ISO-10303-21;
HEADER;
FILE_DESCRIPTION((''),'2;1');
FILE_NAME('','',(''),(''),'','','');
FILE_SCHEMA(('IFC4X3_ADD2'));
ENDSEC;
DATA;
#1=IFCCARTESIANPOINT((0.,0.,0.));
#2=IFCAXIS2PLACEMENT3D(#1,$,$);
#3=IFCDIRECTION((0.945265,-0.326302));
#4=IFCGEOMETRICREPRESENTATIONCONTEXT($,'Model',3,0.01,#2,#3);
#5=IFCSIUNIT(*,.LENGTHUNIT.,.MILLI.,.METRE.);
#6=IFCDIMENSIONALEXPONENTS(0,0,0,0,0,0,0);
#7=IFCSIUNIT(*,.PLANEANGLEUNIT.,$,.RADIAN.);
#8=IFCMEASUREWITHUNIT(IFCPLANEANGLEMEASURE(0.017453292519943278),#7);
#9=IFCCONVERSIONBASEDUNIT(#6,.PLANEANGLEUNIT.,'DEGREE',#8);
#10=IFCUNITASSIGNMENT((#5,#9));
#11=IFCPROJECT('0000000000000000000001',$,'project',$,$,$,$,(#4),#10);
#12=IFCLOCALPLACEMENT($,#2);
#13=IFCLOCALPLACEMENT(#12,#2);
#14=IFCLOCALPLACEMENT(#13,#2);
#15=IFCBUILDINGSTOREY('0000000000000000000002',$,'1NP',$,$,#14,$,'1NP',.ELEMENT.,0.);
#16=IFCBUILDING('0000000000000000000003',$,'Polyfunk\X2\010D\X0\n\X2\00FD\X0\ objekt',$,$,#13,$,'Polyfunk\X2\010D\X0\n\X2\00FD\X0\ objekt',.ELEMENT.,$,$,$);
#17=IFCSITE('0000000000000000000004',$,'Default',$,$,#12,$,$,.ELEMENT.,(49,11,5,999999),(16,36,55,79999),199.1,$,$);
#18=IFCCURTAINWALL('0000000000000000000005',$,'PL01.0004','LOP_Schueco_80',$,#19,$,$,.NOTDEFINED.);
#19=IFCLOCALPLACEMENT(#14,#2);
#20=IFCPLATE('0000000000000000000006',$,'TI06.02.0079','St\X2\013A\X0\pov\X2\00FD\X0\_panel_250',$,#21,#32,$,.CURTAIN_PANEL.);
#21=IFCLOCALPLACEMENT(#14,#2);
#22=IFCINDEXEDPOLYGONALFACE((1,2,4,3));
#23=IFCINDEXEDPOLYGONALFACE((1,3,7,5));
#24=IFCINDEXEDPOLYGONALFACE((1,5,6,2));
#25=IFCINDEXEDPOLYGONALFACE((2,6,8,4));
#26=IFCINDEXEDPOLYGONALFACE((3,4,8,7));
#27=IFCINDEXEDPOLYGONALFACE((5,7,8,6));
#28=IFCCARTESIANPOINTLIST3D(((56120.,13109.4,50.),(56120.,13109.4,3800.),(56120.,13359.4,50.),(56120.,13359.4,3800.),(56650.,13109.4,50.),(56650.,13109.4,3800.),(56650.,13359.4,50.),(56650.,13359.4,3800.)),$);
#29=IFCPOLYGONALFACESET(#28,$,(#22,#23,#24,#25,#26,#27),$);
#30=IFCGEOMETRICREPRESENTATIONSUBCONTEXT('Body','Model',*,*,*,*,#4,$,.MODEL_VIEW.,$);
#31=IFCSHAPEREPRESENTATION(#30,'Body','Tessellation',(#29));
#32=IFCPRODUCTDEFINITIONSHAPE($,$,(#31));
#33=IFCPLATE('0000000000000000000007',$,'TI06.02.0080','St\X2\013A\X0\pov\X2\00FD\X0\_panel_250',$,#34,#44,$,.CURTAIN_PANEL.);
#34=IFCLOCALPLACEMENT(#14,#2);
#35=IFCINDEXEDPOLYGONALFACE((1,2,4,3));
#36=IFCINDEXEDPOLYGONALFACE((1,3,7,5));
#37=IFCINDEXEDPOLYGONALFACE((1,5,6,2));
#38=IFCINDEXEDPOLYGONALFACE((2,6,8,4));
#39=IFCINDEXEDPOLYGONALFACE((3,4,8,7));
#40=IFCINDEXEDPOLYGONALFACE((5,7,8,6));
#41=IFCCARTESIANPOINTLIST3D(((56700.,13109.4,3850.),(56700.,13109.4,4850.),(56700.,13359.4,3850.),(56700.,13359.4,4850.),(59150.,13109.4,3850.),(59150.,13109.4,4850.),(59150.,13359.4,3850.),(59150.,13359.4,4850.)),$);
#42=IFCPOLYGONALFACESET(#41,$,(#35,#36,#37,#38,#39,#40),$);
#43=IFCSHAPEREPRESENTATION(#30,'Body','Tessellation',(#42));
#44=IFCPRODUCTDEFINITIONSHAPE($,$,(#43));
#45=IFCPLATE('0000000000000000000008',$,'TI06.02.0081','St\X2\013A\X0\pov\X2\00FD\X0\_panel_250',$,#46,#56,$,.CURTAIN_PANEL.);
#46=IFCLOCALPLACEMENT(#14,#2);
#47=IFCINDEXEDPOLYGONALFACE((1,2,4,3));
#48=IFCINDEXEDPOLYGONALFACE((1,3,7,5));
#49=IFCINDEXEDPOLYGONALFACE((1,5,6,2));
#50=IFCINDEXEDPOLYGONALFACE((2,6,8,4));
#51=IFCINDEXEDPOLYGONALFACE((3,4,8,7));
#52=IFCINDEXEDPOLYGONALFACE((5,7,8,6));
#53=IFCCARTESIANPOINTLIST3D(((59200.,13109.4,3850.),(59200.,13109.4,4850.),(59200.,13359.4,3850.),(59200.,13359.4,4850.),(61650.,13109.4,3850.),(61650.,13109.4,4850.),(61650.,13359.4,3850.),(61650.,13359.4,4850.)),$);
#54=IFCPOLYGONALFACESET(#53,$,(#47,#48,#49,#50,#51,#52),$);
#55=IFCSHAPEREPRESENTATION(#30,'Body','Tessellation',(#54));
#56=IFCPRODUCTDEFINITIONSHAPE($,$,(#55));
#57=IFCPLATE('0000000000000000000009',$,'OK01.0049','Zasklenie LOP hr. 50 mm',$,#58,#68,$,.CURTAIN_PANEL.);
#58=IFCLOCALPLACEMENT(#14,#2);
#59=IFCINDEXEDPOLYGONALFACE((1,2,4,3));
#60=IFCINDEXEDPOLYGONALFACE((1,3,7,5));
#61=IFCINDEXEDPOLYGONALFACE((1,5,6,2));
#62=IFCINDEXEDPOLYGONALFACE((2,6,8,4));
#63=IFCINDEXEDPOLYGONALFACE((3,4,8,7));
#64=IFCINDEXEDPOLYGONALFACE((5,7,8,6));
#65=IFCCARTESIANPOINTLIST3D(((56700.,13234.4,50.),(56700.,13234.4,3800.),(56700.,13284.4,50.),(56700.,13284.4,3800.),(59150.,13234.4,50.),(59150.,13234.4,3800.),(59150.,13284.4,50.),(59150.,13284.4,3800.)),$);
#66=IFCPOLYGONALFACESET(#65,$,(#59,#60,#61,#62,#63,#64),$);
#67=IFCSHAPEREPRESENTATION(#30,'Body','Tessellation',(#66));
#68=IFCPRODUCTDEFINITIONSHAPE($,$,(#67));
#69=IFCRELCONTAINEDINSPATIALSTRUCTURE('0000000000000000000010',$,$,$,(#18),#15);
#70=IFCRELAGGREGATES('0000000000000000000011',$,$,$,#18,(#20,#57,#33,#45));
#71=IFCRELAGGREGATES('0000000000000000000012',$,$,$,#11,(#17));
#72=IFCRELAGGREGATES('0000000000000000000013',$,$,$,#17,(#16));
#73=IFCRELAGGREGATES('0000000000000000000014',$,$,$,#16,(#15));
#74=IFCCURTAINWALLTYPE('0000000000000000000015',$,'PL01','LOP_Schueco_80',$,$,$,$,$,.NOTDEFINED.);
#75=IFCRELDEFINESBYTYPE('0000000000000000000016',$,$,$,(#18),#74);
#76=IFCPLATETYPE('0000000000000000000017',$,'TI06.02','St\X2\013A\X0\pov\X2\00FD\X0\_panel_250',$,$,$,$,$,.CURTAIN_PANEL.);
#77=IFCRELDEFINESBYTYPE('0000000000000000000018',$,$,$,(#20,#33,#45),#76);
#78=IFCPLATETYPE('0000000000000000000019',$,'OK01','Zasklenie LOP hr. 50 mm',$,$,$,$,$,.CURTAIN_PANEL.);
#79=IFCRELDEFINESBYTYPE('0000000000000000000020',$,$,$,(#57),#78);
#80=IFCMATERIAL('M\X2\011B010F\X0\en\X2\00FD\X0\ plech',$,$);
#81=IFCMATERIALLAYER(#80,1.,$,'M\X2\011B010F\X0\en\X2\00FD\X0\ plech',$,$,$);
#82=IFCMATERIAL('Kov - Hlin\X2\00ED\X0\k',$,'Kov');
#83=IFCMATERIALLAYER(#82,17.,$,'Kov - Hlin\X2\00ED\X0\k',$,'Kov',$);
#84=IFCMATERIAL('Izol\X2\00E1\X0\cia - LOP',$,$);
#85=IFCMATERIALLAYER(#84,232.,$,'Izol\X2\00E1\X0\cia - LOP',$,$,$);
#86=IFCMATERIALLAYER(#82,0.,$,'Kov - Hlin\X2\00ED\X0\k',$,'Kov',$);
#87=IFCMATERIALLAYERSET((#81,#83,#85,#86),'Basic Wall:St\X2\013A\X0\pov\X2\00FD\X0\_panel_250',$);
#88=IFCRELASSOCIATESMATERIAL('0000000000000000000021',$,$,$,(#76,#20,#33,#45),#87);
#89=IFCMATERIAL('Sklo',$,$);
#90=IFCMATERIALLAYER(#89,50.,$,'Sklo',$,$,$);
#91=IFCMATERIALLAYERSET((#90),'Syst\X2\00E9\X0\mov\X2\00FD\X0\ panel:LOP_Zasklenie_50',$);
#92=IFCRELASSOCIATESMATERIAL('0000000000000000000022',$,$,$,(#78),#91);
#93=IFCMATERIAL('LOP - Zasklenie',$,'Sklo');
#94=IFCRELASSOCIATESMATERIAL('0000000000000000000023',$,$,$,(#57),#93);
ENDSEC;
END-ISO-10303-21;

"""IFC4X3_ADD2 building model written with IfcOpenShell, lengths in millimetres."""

from ifc_helpers import new_model, entity, si_unit, converted_unit, direction, frame, frame_2d, origin, place, context, subcontext, project, spatial, rectangle, extrude, source, transform, mapped, material, layer, layer_set, layer_usage, type_object, type_shapes, element, aggregate, save


model = new_model("IFC4X3_ADD2")

# Units and contexts
model_context = context("Model", 3, precision=0.01, world=origin(), true_north=direction((0.945265, -0.326302)))
body_context = subcontext(model_context, "Body", "Model", "MODEL_VIEW")
ifc_project = project(units=[si_unit("LENGTHUNIT", "METRE", prefix="MILLI"), converted_unit("PLANEANGLEUNIT", "DEGREE", entity("IfcPlaneAngleMeasure", 0.017453292519943278), si_unit("PLANEANGLEUNIT", "RADIAN"), dimensions=[0, 0, 0, 0, 0, 0, 0])], contexts=[model_context])

# Site, building, storey
site_placement = place(None, origin())
site = spatial("IfcSite", under=ifc_project, at=site_placement, Name="Default", CompositionType="ELEMENT", RefLatitude=(49, 11, 5, 999999), RefLongitude=(16, 36, 55, 79999), RefElevation=199.1)
building_placement = place(site_placement, origin())
building = spatial("IfcBuilding", under=site, at=building_placement, Name="Polyfunkčný objekt", LongName="Polyfunkčný objekt", CompositionType="ELEMENT")
storey_placement = place(building_placement, origin())
storey = spatial("IfcBuildingStorey", under=building, at=storey_placement, Name="1NP", LongName="1NP", CompositionType="ELEMENT", Elevation=0.0)

# Curtain wall, plates
curtain_wall_type = type_object("IfcCurtainWallType", Name="PL01", Description="LOP_Schueco_80", PredefinedType="NOTDEFINED")
curtain_wall_placement = place(storey_placement, origin())
curtain_wall = element("IfcCurtainWall", 1, at=curtain_wall_placement, inside=storey, type_object=curtain_wall_type, Name="PL01.0004", Description="LOP_Schueco_80", PredefinedType="NOTDEFINED")
ifc_material_1 = material(Name="Měďený plech")
ifc_layer_1 = layer(ifc_material_1, 1.0, Name="Měďený plech")
ifc_material_2 = material(Name="Kov - Hliník", Category="Kov")
ifc_layer_2 = layer(ifc_material_2, 17.0, Name="Kov - Hliník", Category="Kov")
ifc_material_3 = material(Name="Izolácia - LOP")
ifc_layer_3 = layer(ifc_material_3, 232.0, Name="Izolácia - LOP")
ifc_layer_4 = layer(ifc_material_2, 0.0, Name="Kov - Hliník", Category="Kov")
ifc_layer_set_1 = layer_set([ifc_layer_1, ifc_layer_2, ifc_layer_3, ifc_layer_4], Name="Basic Wall:Stĺpový_panel_250")
ifc_layer_usage_1 = layer_usage(ifc_layer_set_1, "AXIS2", "NEGATIVE", 125.0)
plate_type_1 = type_object("IfcPlateType", Name="TI06.02", Description="Stĺpový_panel_250", PredefinedType="CURTAIN_PANEL", material=ifc_layer_set_1)
plate_1_placement = place(storey_placement, frame((56120.0, 13234.4, 50.0)))
plate_1 = element("IfcPlate", 2, at=plate_1_placement, type_object=plate_type_1, material=ifc_layer_usage_1, Name="TI06.02.0079", Description="Stĺpový_panel_250", PredefinedType="CURTAIN_PANEL", context=body_context, shape_type="SweptSolid", body=[
    extrude(rectangle(XDim=250.0, YDim=530.0, at=frame_2d((0.0, 0.0), x_axis=(1.0, 0.0))), frame((265.0, 0.0, 0.0), z_axis=(0.0, 0.0, 1.0), x_axis=(0.0, 1.0, 0.0)), (0.0, 0.0, 1.0), 3750.0),
])
ifc_layer_usage_2 = layer_usage(ifc_layer_set_1, "AXIS2", "NEGATIVE", 125.0)
plate_2_placement = place(storey_placement, frame((56700.0, 13234.4, 3850.0)))
plate_2 = element("IfcPlate", 3, at=plate_2_placement, type_object=plate_type_1, material=ifc_layer_usage_2, Name="TI06.02.0080", Description="Stĺpový_panel_250", PredefinedType="CURTAIN_PANEL", context=body_context, shape_type="SweptSolid", body=[
    extrude(rectangle(XDim=250.0, YDim=2450.0, at=frame_2d((0.0, 0.0), x_axis=(1.0, 0.0))), frame((1225.0, 0.0, 0.0), z_axis=(0.0, 0.0, 1.0), x_axis=(0.0, 1.0, 0.0)), (0.0, 0.0, 1.0), 1000.0),
])
ifc_layer_usage_3 = layer_usage(ifc_layer_set_1, "AXIS2", "NEGATIVE", 125.0)
plate_3_placement = place(storey_placement, frame((59200.0, 13234.4, 3850.0)))
plate_3 = element("IfcPlate", 4, at=plate_3_placement, type_object=plate_type_1, material=ifc_layer_usage_3, Name="TI06.02.0081", Description="Stĺpový_panel_250", PredefinedType="CURTAIN_PANEL", context=body_context, shape_type="SweptSolid", body=[
    extrude(rectangle(XDim=250.0, YDim=2450.0, at=frame_2d((0.0, 0.0), x_axis=(1.0, 0.0))), frame((1225.0, 0.0, 0.0), z_axis=(0.0, 0.0, 1.0), x_axis=(0.0, 1.0, 0.0)), (0.0, 0.0, 1.0), 1000.0),
])
ifc_material_4 = material(Name="LOP - Zasklenie", Category="Sklo")
ifc_material_5 = material(Name="Sklo")
ifc_layer_5 = layer(ifc_material_5, 50.0, Name="Sklo")
ifc_layer_set_2 = layer_set([ifc_layer_5], Name="Systémový panel:LOP_Zasklenie_50")
plate_type_2 = type_object("IfcPlateType", Name="OK01", Description="Zasklenie LOP hr. 50 mm", PredefinedType="CURTAIN_PANEL", material=ifc_layer_set_2)
shared_shape_1 = source(origin(), body_context, "Body", "SweptSolid", [
    extrude(rectangle(XDim=3750.0, YDim=2450.0, at=frame_2d((-141.7, 0.0), x_axis=(1.0, 0.0))), frame((0.0, 0.0, 2016.7), z_axis=(0.0, 1.0, 0.0), x_axis=(0.0, 0.0, 1.0)), (0.0, 0.0, 1.0), 50.0),
])
type_shapes(plate_type_2, [shared_shape_1])
plate_4_placement = place(curtain_wall_placement, frame((57925.0, 13234.4, 50.0)))
plate_4 = element("IfcPlate", 5, at=plate_4_placement, type_object=plate_type_2, material=ifc_material_4, Name="OK01.0049", Description="Zasklenie LOP hr. 50 mm", PredefinedType="CURTAIN_PANEL", context=body_context, shape_type="MappedRepresentation", body=[
    mapped(shared_shape_1, transform((0.0, 0.0, 0.0), scale=1.0)),
])
aggregate(curtain_wall, [plate_1, plate_4, plate_2, plate_3])

save(model, "model.ifc")
